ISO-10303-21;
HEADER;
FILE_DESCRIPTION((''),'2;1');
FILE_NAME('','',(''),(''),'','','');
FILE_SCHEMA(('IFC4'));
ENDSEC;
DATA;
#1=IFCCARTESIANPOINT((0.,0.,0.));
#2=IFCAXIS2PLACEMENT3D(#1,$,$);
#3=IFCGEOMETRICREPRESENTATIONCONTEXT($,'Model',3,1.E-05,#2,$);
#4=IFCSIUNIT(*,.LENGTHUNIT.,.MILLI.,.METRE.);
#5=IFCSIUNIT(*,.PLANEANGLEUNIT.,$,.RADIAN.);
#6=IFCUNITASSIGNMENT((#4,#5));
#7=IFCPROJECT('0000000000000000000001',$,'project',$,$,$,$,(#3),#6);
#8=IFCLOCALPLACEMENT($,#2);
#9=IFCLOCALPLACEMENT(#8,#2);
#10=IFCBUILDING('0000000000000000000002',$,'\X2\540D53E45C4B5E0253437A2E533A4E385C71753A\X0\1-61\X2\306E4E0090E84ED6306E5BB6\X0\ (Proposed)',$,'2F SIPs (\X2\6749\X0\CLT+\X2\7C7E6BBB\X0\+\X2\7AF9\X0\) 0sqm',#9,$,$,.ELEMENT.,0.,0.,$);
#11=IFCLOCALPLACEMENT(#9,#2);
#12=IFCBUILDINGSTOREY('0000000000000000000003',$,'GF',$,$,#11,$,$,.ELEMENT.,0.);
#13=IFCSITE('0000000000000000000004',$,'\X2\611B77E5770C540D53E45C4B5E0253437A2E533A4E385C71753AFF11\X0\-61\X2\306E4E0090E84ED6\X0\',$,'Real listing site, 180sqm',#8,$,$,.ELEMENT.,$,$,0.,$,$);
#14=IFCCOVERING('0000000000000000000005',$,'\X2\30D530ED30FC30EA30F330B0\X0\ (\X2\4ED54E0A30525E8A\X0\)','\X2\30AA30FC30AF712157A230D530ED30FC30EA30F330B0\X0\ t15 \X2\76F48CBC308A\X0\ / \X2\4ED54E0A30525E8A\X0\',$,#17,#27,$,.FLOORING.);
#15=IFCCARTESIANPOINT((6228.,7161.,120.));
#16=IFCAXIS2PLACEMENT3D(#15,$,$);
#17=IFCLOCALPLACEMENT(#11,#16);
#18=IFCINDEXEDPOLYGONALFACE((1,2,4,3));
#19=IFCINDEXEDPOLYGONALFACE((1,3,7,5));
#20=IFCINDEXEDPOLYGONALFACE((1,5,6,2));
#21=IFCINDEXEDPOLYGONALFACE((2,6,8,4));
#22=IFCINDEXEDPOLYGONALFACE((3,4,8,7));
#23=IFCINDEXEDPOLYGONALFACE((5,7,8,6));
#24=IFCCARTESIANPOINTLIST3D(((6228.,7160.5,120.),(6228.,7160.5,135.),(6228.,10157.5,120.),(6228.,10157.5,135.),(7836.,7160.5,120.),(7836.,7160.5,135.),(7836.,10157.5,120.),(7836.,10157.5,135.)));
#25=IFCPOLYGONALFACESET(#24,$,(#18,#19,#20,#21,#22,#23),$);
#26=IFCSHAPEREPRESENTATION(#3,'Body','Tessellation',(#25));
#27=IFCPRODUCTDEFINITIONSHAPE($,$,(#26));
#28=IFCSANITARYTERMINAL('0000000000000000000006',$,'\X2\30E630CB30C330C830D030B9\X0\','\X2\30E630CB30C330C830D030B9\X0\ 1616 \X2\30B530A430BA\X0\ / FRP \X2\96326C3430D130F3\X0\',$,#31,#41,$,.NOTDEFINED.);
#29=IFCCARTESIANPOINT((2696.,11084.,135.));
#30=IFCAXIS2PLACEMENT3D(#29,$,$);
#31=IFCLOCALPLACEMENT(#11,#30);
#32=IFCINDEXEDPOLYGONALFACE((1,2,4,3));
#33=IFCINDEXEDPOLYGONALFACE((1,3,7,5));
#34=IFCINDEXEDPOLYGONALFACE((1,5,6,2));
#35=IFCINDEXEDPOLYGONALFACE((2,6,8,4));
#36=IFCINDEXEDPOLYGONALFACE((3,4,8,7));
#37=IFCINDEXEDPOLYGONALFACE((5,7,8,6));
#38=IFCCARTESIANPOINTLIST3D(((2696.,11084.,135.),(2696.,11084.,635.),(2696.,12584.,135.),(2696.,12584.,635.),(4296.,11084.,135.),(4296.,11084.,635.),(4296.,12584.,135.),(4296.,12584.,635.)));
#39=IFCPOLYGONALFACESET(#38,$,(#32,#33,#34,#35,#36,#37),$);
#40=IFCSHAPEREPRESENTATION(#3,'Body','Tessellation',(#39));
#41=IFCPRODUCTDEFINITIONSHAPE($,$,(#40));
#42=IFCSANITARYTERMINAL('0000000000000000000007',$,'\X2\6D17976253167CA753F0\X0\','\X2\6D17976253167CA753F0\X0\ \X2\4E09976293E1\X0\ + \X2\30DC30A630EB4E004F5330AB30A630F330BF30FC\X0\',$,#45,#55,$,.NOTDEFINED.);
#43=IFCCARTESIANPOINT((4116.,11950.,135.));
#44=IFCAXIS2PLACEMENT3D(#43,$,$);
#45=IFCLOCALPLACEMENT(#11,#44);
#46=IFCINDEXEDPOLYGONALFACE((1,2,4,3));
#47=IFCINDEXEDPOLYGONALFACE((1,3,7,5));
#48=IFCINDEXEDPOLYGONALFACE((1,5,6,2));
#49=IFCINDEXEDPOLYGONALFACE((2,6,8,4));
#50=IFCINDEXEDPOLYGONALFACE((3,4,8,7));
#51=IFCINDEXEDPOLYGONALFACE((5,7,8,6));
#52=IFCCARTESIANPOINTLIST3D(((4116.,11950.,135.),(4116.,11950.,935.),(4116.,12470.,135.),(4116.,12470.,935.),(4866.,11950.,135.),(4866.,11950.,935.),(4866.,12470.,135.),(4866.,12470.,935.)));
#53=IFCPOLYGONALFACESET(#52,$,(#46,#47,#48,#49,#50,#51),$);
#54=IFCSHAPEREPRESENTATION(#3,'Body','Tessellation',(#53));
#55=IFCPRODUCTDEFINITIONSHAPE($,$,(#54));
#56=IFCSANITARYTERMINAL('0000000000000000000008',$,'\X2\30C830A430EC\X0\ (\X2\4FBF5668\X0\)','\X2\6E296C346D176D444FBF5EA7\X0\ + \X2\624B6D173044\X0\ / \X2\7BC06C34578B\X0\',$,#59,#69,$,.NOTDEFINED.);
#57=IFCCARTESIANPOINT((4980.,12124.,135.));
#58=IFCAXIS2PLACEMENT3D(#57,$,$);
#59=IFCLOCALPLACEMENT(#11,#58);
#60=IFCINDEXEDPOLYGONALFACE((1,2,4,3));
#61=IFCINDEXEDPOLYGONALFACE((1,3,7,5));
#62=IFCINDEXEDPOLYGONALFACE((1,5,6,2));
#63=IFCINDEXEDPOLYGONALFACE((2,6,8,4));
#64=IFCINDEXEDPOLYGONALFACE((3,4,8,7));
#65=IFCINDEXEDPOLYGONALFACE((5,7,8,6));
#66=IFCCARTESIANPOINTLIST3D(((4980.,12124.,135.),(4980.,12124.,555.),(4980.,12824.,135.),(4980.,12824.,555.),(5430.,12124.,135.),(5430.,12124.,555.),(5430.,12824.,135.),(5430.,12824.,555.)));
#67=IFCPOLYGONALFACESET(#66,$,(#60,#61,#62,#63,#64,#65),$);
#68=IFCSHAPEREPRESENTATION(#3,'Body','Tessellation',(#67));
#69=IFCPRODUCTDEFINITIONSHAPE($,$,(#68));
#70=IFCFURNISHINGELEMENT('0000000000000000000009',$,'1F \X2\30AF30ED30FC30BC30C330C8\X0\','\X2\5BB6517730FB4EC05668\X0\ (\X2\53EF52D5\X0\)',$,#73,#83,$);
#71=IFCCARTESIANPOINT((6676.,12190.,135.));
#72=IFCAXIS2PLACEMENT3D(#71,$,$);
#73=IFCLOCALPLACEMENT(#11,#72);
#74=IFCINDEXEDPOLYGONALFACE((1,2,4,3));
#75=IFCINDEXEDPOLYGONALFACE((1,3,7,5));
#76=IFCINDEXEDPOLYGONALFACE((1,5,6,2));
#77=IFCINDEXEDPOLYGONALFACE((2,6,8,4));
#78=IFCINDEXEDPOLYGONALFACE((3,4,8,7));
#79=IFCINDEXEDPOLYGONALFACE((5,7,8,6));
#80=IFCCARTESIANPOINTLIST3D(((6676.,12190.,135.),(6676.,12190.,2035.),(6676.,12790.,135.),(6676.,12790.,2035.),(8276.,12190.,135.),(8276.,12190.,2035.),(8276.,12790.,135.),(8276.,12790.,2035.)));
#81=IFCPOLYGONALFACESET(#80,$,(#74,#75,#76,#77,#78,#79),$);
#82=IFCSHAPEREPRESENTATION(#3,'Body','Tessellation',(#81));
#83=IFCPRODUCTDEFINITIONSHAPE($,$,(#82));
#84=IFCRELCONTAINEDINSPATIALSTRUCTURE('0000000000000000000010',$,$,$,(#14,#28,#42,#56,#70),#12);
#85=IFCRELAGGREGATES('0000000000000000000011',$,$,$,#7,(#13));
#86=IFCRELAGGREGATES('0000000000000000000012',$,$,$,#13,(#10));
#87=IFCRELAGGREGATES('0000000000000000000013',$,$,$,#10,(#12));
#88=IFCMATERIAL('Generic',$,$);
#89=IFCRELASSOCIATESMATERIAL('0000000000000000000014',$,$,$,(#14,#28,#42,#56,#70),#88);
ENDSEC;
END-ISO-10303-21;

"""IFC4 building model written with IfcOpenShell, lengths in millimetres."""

from ifc_helpers import new_model, si_unit, frame, frame_2d, origin, place, context, project, spatial, rectangle, extrude, material, element, save


model = new_model("IFC4")

# Units and contexts
model_context = context("Model", 3, precision=1e-05, world=origin())
ifc_project = project(units=[si_unit("LENGTHUNIT", "METRE", prefix="MILLI"), si_unit("PLANEANGLEUNIT", "RADIAN")], contexts=[model_context])

# Site, building, storey
site_placement = place(None, origin())
site = spatial("IfcSite", under=ifc_project, at=site_placement, Name="愛知県名古屋市千種区丸山町１-61の一部他", ObjectType="Real listing site, 180sqm", CompositionType="ELEMENT", RefElevation=0.0)
building_placement = place(site_placement, origin())
building = spatial("IfcBuilding", under=site, at=building_placement, Name="名古屋市千種区丸山町1-61の一部他の家 (Proposed)", ObjectType="2F SIPs (杉CLT+籾殻+竹) 0sqm", CompositionType="ELEMENT", ElevationOfRefHeight=0.0, ElevationOfTerrain=0.0)
storey_placement = place(building_placement, origin())
storey = spatial("IfcBuildingStorey", under=building, at=storey_placement, Name="GF", CompositionType="ELEMENT", Elevation=0.0)

# Covering
ifc_material_1 = material(Name="Generic")
covering_1_placement = place(storey_placement, frame((6228.0, 7161.0, 120.0)))
element("IfcCovering", 1, at=covering_1_placement, inside=storey, material=ifc_material_1, Name="フローリング (仕上げ床)", Description="オーク無垢フローリング t15 直貼り / 仕上げ床", PredefinedType="FLOORING", context=model_context, shape_type="SweptSolid", body=[
    extrude(rectangle(XDim=1608.0, YDim=2997.0, at=frame_2d((804.0, 1498.0))), frame((6228.0, 7161.0, 120.0)), (0.0, 0.0, 1.0), 15.0),
])

# Sanitary terminals
sanitary_terminal_1_placement = place(storey_placement, frame((2696.0, 11084.0, 135.0)))
element("IfcSanitaryTerminal", 2, at=sanitary_terminal_1_placement, inside=storey, material=ifc_material_1, Name="ユニットバス", Description="ユニットバス 1616 サイズ / FRP 防水パン", PredefinedType="NOTDEFINED", context=model_context, shape_type="SweptSolid", body=[
    extrude(rectangle(XDim=1600.0, YDim=1500.0, at=frame_2d((800.0, 750.0))), frame((2696.0, 11084.0, 135.0)), (0.0, 0.0, 1.0), 500.0),
])
sanitary_terminal_2_placement = place(storey_placement, frame((4116.0, 11950.0, 135.0)))
element("IfcSanitaryTerminal", 3, at=sanitary_terminal_2_placement, inside=storey, material=ifc_material_1, Name="洗面化粧台", Description="洗面化粧台 三面鏡 + ボウル一体カウンター", PredefinedType="NOTDEFINED", context=model_context, shape_type="SweptSolid", body=[
    extrude(rectangle(XDim=750.0, YDim=520.0, at=frame_2d((375.0, 260.0))), frame((4116.0, 11950.0, 135.0)), (0.0, 0.0, 1.0), 800.0),
])
sanitary_terminal_3_placement = place(storey_placement, frame((4980.0, 12124.0, 135.0)))
element("IfcSanitaryTerminal", 4, at=sanitary_terminal_3_placement, inside=storey, material=ifc_material_1, Name="トイレ (便器)", Description="温水洗浄便座 + 手洗い / 節水型", PredefinedType="NOTDEFINED", context=model_context, shape_type="SweptSolid", body=[
    extrude(rectangle(XDim=450.0, YDim=700.0, at=frame_2d((225.0, 350.0))), frame((4980.0, 12124.0, 135.0)), (0.0, 0.0, 1.0), 420.0),
])

# Furnishing element
furnishing_placement = place(storey_placement, frame((6676.0, 12190.0, 135.0)))
element("IfcFurnishingElement", 5, at=furnishing_placement, inside=storey, material=ifc_material_1, Name="1F クローゼット", Description="家具・什器 (可動)", context=model_context, shape_type="SweptSolid", body=[
    extrude(rectangle(XDim=1600.0, YDim=600.0, at=frame_2d((800.0, 300.0))), frame((6676.0, 12190.0, 135.0)), (0.0, 0.0, 1.0), 1900.0),
])

save(model, "model.ifc")
